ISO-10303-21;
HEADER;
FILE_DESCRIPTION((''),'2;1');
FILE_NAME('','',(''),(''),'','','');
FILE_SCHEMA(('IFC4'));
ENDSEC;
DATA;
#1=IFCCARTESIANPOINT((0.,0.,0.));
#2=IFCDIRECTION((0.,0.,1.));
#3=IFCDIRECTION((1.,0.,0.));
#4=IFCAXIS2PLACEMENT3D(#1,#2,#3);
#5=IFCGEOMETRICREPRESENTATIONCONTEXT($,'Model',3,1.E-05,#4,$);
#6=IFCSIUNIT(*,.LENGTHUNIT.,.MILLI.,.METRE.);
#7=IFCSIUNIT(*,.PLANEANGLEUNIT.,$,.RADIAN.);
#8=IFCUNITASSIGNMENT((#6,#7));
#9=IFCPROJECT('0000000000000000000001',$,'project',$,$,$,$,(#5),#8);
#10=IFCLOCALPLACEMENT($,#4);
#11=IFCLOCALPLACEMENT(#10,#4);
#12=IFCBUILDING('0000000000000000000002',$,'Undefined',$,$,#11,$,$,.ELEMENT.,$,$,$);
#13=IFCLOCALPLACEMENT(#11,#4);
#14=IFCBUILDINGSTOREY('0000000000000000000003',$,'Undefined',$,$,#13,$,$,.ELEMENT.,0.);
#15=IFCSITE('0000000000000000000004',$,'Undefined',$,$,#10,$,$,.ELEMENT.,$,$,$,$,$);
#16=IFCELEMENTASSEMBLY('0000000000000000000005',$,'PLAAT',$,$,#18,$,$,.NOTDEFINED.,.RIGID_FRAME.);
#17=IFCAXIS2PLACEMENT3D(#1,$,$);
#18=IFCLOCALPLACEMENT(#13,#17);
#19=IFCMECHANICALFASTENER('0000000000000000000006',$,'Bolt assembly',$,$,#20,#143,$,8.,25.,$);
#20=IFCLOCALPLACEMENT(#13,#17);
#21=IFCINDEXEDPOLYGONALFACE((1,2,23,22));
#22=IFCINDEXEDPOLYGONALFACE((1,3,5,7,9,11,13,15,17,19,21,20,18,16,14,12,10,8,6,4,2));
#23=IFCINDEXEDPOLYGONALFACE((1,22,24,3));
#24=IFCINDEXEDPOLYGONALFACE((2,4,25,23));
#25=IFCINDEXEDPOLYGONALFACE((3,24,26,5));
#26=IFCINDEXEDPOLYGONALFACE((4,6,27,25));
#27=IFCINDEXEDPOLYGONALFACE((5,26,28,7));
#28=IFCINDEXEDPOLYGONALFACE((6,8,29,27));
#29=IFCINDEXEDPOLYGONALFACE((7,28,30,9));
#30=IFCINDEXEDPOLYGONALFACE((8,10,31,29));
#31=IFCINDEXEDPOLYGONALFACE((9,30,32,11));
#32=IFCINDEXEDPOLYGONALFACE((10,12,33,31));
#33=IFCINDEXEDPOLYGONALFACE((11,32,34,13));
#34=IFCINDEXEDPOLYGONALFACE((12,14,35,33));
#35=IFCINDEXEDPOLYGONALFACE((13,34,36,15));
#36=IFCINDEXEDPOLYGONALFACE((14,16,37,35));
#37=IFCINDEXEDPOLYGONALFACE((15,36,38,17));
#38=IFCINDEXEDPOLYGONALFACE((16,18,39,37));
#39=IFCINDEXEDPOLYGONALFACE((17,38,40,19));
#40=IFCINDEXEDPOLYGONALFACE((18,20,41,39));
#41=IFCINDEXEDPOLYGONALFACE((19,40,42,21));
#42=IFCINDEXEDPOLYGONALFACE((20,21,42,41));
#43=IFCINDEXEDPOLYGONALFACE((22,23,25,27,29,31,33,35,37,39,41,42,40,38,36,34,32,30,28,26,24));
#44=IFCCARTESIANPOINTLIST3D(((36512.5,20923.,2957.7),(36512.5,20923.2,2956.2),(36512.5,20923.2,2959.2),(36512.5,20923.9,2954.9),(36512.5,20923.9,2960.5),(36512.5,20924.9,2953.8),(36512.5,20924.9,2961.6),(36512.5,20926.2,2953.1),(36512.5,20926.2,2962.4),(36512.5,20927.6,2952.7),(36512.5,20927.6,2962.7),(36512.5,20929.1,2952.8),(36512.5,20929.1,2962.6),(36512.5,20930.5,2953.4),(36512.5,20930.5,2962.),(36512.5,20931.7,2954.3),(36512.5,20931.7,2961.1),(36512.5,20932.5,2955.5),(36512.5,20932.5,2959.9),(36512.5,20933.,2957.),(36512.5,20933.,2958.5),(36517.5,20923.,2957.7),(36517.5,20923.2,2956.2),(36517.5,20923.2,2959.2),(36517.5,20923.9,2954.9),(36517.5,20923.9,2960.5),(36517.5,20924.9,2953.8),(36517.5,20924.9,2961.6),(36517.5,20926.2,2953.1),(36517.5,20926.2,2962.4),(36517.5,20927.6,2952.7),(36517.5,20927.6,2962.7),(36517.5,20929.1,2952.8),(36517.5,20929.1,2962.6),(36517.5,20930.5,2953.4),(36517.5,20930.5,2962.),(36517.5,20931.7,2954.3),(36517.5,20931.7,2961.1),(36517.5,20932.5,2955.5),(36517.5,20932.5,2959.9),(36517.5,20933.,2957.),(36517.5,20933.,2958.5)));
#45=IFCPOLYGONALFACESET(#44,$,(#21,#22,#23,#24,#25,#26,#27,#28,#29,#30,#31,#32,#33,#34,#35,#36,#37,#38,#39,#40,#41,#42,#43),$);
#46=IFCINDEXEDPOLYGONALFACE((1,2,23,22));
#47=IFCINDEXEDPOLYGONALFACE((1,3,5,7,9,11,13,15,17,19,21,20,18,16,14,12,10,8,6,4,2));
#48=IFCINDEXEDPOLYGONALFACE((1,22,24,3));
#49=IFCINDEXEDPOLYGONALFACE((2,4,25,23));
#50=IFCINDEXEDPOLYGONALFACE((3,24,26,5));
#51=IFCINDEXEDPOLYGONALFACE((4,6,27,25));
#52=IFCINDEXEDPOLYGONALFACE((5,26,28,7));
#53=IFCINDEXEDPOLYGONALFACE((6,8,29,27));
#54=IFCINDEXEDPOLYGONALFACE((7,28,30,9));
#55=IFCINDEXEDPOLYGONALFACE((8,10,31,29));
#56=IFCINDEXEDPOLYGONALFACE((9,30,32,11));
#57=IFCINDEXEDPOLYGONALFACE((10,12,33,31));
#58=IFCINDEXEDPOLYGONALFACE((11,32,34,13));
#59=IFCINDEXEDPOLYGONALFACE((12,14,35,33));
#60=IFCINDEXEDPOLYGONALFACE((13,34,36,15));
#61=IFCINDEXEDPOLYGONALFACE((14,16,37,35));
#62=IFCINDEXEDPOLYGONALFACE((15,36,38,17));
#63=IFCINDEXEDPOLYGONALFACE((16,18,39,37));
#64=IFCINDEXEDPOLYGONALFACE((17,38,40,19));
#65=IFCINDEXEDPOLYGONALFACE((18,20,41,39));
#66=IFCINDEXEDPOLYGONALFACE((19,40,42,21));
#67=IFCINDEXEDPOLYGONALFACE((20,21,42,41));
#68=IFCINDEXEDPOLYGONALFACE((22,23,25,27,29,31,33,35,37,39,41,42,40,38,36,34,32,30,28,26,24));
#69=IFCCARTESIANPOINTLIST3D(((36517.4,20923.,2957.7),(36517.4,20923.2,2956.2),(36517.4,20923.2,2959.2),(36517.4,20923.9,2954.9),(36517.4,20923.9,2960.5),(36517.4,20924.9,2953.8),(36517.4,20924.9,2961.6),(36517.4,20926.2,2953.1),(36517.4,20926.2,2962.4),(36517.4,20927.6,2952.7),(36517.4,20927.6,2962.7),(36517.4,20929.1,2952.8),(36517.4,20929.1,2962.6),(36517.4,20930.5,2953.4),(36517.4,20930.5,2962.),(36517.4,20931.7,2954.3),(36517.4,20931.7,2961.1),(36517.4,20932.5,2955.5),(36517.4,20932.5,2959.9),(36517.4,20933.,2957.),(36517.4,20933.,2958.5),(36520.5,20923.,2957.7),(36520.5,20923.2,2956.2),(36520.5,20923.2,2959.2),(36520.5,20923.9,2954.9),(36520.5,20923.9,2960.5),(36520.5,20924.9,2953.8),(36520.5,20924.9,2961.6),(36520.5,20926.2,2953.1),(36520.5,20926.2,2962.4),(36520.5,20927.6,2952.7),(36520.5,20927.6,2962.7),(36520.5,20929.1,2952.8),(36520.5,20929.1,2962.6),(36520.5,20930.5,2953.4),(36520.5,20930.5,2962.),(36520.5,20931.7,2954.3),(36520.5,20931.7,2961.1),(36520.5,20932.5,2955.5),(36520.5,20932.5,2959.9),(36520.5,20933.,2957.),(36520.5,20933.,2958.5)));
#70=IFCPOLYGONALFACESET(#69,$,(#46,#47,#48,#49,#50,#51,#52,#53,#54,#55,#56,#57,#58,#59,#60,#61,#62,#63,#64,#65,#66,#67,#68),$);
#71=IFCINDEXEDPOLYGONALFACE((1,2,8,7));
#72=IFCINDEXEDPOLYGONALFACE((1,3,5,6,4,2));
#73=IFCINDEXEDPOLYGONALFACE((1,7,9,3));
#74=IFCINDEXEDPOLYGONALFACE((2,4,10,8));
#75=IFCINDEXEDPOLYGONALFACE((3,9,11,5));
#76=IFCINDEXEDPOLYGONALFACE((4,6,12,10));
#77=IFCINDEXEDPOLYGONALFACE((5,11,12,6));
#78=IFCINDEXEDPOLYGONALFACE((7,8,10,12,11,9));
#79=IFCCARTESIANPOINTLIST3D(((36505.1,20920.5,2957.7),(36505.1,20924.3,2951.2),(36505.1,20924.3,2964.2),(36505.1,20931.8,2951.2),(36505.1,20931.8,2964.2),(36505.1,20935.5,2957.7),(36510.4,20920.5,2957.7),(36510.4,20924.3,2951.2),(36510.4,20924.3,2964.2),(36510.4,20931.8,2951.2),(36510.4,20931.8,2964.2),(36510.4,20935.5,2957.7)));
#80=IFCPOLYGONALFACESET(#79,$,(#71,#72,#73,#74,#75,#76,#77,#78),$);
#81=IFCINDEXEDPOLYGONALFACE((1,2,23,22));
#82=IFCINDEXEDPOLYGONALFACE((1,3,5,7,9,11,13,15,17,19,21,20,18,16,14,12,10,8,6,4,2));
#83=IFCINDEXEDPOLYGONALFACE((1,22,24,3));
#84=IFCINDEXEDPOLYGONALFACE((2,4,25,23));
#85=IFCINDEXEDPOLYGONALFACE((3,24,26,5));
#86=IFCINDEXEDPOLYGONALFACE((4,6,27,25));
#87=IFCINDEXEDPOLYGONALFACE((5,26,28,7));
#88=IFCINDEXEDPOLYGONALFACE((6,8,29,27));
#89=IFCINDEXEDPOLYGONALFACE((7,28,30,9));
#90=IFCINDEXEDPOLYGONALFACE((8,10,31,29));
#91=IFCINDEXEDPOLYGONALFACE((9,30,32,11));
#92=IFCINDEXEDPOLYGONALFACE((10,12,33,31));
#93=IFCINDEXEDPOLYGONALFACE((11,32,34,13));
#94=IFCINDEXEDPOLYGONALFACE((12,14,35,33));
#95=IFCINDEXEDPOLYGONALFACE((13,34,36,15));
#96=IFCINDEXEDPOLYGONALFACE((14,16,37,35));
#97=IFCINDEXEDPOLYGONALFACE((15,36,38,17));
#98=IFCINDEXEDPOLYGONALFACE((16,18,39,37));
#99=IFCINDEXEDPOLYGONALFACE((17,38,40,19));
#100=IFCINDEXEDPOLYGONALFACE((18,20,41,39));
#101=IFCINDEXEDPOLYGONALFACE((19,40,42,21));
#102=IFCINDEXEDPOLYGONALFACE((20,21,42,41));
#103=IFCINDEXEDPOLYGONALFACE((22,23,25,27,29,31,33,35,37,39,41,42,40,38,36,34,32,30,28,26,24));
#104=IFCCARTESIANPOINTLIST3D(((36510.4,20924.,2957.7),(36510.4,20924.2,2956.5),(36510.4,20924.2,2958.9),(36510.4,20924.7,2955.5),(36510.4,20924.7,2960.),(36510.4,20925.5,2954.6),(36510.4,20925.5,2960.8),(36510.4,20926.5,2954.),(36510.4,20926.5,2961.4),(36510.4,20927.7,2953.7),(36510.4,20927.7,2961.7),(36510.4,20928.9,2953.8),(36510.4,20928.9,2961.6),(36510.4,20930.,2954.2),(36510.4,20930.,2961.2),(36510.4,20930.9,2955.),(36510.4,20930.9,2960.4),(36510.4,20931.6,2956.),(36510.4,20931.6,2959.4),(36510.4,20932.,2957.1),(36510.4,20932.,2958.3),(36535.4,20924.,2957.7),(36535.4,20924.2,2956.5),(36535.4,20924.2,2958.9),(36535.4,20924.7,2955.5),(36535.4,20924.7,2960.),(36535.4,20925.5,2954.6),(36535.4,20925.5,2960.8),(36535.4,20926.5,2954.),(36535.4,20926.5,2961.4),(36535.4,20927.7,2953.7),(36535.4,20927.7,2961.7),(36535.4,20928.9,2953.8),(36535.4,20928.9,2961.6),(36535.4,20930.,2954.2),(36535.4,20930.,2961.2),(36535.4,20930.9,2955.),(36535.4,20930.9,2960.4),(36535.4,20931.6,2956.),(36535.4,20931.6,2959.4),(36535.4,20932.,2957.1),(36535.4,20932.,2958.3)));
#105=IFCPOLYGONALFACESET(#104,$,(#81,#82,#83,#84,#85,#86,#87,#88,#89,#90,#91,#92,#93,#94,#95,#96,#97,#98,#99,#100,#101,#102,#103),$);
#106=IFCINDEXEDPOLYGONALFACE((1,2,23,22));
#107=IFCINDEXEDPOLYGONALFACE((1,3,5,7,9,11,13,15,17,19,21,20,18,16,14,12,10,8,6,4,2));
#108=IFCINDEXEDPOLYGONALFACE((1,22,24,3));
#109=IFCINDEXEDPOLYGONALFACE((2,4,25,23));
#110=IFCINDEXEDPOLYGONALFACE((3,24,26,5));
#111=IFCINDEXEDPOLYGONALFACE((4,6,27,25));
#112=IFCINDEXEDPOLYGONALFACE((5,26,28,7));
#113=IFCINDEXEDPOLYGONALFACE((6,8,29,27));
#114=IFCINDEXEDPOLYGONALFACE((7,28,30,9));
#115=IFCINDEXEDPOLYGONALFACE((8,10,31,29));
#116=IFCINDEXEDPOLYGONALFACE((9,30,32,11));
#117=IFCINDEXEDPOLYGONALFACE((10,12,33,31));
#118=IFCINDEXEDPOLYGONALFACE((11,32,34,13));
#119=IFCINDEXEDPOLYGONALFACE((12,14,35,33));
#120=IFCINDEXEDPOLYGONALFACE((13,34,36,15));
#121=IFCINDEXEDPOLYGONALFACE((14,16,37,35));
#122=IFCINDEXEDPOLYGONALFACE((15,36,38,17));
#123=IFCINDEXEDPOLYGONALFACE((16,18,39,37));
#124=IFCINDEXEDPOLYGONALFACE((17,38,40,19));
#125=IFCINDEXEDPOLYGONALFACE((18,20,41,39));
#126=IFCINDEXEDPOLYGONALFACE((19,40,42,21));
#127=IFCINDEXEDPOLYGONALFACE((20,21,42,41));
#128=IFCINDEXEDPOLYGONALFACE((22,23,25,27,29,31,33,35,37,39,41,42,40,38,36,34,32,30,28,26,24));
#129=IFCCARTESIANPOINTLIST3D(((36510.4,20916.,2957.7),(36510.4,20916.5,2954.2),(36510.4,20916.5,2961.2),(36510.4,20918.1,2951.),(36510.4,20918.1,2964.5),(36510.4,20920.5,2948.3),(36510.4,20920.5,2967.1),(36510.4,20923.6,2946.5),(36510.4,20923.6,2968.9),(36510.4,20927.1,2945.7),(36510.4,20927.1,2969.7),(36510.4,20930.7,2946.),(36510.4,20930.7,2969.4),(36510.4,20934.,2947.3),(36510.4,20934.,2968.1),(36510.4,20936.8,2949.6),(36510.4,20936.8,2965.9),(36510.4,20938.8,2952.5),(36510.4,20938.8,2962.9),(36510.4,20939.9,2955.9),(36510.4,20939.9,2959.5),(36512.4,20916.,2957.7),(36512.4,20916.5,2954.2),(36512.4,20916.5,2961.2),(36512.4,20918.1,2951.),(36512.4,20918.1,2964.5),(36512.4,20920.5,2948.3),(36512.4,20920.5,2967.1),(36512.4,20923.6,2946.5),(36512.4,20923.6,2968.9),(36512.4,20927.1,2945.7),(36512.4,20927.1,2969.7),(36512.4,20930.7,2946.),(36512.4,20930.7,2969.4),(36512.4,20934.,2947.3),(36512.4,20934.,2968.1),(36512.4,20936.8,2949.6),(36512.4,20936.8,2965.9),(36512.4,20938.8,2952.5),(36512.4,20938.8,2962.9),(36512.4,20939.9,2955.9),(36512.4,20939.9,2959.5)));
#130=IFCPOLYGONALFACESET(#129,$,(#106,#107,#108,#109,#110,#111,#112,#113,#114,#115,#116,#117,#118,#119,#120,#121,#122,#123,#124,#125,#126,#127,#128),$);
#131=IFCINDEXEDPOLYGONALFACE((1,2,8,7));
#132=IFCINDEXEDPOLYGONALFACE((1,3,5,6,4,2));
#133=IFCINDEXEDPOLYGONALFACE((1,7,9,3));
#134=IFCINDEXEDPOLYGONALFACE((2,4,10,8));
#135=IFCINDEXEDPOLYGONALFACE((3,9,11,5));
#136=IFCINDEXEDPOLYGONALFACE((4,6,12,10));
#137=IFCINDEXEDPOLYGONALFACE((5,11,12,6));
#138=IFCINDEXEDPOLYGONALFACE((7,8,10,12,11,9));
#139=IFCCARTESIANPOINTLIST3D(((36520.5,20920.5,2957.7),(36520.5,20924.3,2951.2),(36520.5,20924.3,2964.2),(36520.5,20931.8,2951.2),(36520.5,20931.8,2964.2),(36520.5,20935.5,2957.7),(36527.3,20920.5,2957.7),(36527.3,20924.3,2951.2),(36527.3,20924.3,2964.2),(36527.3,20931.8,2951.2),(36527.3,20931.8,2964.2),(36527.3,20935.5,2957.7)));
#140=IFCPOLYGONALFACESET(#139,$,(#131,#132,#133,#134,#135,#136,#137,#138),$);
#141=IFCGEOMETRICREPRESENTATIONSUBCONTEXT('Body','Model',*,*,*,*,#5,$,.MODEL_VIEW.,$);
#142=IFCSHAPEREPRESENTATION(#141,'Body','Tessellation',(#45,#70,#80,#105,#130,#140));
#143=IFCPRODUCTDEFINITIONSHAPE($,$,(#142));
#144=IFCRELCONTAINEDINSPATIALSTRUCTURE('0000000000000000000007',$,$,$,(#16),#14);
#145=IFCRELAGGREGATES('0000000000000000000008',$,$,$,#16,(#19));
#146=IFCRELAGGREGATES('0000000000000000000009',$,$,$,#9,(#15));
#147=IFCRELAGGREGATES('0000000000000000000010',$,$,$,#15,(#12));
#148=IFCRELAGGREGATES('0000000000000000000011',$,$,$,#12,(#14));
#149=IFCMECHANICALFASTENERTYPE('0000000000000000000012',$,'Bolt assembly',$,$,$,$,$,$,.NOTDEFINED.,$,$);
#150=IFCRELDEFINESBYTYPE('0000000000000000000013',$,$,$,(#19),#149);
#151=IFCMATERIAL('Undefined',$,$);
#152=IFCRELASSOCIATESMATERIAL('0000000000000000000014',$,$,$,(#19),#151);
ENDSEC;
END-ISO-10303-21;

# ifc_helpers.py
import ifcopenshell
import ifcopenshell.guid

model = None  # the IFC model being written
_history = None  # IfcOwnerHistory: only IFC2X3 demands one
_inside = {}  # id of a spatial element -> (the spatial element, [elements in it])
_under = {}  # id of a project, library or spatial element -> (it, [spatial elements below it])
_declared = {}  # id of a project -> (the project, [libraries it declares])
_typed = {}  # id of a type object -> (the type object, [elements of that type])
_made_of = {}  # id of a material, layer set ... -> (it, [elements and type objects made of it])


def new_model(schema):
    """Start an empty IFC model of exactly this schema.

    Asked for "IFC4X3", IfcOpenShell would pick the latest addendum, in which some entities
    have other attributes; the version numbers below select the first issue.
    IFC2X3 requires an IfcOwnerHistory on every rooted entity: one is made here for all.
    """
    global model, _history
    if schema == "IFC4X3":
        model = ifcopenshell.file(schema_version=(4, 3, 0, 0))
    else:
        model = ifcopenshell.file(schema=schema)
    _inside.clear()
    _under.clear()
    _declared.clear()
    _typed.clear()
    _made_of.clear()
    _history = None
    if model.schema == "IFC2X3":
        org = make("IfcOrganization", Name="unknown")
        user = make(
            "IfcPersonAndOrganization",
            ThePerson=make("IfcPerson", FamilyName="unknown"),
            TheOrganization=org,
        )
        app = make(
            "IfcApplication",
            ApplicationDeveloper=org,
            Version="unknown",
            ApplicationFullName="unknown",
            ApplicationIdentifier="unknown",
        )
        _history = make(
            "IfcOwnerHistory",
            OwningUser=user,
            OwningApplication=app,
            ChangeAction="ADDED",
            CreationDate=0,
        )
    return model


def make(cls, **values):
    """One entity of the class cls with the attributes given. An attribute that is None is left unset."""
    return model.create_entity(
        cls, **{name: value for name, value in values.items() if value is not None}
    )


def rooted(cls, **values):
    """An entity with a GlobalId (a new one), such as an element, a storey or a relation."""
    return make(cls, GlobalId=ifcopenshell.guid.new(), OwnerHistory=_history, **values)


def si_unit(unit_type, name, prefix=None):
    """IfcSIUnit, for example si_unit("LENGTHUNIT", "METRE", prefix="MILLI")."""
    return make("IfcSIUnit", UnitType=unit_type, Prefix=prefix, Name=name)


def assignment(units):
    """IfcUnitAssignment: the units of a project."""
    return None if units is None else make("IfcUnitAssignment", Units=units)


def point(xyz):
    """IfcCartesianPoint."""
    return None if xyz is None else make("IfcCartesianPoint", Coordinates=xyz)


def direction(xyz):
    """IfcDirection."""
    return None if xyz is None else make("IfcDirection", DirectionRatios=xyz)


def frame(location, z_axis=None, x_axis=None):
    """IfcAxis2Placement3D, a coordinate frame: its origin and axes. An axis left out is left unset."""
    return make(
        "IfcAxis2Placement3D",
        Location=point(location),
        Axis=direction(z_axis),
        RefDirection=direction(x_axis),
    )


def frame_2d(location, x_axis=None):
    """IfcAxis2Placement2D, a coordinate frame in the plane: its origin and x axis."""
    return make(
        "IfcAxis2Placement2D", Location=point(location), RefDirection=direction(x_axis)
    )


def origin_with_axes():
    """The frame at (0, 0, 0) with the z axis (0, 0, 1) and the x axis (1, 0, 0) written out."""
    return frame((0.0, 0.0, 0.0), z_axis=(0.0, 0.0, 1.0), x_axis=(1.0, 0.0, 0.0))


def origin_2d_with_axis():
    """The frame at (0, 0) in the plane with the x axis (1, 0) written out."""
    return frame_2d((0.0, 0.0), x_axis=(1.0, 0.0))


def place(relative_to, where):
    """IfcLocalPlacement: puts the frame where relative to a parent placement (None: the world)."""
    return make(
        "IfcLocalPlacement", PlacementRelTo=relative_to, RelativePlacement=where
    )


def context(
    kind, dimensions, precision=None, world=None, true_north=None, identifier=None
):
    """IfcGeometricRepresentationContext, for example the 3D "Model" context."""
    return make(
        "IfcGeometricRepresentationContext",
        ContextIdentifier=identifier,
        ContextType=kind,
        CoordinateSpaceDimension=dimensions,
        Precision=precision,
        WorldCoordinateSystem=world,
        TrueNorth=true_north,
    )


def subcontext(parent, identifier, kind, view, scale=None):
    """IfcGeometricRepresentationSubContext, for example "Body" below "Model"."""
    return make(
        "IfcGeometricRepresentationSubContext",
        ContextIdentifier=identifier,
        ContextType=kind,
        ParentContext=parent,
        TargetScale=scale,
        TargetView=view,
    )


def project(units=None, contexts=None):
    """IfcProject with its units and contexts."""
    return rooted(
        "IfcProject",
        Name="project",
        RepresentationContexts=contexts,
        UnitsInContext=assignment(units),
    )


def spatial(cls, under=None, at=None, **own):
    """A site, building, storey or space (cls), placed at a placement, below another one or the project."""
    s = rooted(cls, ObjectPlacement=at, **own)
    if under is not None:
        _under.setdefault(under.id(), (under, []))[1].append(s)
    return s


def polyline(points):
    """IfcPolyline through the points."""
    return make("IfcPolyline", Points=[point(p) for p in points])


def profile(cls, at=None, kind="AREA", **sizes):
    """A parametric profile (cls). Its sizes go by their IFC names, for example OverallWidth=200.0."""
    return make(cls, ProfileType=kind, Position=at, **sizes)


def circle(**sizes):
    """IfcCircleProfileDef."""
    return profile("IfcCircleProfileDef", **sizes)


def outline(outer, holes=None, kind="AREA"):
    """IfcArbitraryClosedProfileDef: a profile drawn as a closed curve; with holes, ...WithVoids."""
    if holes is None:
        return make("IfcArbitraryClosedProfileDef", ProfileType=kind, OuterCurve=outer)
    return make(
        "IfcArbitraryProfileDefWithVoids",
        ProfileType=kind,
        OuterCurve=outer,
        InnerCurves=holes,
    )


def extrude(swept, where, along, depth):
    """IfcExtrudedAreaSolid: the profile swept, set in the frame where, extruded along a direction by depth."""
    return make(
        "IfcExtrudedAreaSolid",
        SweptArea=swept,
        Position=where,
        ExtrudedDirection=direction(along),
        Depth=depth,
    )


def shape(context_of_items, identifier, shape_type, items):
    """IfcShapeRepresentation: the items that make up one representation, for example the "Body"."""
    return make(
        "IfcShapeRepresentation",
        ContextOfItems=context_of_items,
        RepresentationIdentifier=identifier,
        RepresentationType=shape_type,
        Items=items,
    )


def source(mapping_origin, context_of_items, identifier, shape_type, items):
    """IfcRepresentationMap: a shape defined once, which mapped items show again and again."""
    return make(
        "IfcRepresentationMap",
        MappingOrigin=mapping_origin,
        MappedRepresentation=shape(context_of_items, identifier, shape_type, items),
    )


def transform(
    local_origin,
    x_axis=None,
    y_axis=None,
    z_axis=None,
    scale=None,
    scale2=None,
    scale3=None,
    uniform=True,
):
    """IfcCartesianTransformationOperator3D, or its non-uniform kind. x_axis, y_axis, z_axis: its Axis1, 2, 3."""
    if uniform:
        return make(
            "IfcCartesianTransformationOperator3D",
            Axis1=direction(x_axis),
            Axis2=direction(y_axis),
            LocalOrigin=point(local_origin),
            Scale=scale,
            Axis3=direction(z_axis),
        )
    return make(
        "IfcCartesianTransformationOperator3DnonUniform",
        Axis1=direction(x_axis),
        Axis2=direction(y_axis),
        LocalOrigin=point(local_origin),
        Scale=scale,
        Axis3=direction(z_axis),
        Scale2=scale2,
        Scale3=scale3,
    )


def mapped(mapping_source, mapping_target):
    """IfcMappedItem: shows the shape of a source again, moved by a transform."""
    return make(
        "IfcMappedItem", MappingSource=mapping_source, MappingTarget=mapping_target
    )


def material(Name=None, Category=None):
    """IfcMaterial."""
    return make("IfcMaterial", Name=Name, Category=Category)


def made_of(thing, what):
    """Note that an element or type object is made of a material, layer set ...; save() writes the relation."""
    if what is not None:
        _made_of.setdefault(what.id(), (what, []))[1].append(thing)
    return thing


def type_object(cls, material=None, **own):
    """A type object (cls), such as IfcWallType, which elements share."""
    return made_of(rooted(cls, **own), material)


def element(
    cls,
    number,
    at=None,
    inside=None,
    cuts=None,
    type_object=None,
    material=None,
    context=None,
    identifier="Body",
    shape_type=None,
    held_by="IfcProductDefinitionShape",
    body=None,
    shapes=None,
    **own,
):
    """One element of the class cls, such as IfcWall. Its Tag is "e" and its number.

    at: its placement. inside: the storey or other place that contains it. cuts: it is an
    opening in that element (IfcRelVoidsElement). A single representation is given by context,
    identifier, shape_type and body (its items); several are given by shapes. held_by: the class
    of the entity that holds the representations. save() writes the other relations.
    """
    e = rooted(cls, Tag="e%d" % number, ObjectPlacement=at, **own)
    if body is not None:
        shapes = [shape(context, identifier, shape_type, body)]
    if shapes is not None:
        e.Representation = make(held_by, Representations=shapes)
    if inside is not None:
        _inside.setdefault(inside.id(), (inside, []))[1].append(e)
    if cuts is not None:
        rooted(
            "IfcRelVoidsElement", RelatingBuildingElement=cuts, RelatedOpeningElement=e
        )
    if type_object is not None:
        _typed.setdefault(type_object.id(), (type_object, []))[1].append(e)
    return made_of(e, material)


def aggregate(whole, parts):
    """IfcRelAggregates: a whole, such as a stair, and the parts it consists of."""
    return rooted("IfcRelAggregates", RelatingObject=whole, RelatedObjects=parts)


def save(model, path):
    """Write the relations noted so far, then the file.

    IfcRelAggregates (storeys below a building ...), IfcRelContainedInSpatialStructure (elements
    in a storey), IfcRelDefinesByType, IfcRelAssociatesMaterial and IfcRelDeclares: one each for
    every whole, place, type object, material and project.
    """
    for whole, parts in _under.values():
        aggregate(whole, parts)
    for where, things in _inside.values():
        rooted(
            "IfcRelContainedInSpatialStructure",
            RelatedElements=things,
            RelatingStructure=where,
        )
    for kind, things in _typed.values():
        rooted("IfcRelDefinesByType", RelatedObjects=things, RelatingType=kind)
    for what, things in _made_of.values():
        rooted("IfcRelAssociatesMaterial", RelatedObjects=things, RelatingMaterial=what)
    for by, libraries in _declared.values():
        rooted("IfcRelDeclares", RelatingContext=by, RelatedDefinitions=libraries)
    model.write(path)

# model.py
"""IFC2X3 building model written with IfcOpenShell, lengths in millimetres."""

from ifc_helpers import new_model, si_unit, frame, origin_with_axes, origin_2d_with_axis, place, context, subcontext, project, spatial, polyline, circle, outline, extrude, source, transform, mapped, material, type_object, element, aggregate, save


model = new_model("IFC2X3")

# Units and contexts
model_context = context("Model", 3, precision=1e-05, world=origin_with_axes())
body_context = subcontext(model_context, "Body", "Model", "MODEL_VIEW")
ifc_project = project(units=[si_unit("LENGTHUNIT", "METRE", prefix="MILLI"), si_unit("PLANEANGLEUNIT", "RADIAN")], contexts=[model_context])

# Site, building, storey
site_placement = place(None, origin_with_axes())
site = spatial("IfcSite", under=ifc_project, at=site_placement, Name="Undefined", CompositionType="ELEMENT")
building_placement = place(site_placement, origin_with_axes())
building = spatial("IfcBuilding", under=site, at=building_placement, Name="Undefined", CompositionType="ELEMENT")
storey_placement = place(building_placement, origin_with_axes())
storey = spatial("IfcBuildingStorey", under=building, at=storey_placement, Name="Undefined", CompositionType="ELEMENT", Elevation=0.0)

# Shared definitions
ifc_material_1 = material(Name="Undefined")
mechanical_fastener_type = type_object("IfcMechanicalFastenerType", Name="Bolt assembly")
shared_shape_1 = source(origin_with_axes(), body_context, "Body", "SweptSolid", [
    extrude(circle(Radius=5.0, at=origin_2d_with_axis()), frame((0.0, 7.5, 0.0), z_axis=(0.0, 1.0, 0.0), x_axis=(1.0, 0.0, 0.0)), (0.0, 0.0, 1.0), 5.0),
    extrude(circle(Radius=5.0, at=origin_2d_with_axis()), frame((0.0, 12.4, 0.0), z_axis=(0.0, 1.0, 0.0), x_axis=(1.0, 0.0, 0.0)), (0.0, 0.0, 1.0), 3.1),
    extrude(outline(polyline([(7.5, 0.0), (3.8, 6.5), (-3.8, 6.5), (-7.5, 0.0), (-3.8, -6.5), (3.8, -6.5), (7.5, 0.0)])), frame((0.0, 0.1, 0.0), z_axis=(0.0, 1.0, 0.0), x_axis=(1.0, 0.0, 0.0)), (0.0, 0.0, 1.0), 5.3),
    extrude(circle(Radius=4.0, at=origin_2d_with_axis()), frame((0.0, 5.4, 0.0), z_axis=(0.0, 1.0, 0.0), x_axis=(1.0, 0.0, 0.0)), (0.0, 0.0, 1.0), 25.0),
    extrude(circle(Radius=12.0, at=origin_2d_with_axis()), frame((0.0, 5.4, 0.0), z_axis=(0.0, 1.0, 0.0), x_axis=(1.0, 0.0, 0.0)), (0.0, 0.0, 1.0), 2.0),
    extrude(outline(polyline([(7.5, 0.0), (3.8, 6.5), (-3.8, 6.5), (-7.5, 0.0), (-3.8, -6.5), (3.8, -6.5), (7.5, 0.0)])), frame((0.0, 15.5, 0.0), z_axis=(0.0, 1.0, 0.0), x_axis=(1.0, 0.0, 0.0)), (0.0, 0.0, 1.0), 6.8),
])

# Element assembly, mechanical fastener
assembly_1_placement = place(storey_placement, origin_with_axes())
assembly_1 = element("IfcElementAssembly", 1, at=assembly_1_placement, inside=storey, Name="PLAAT", AssemblyPlace="NOTDEFINED", PredefinedType="RIGID_FRAME")
mechanical_fastener_1_placement = place(assembly_1_placement, frame((36505.0, 20928.0, 2957.7), z_axis=(0.0, 0.000002, 1.0), x_axis=(0.0, -1.0, 0.000002)))
mechanical_fastener_1 = element("IfcMechanicalFastener", 2, at=mechanical_fastener_1_placement, type_object=mechanical_fastener_type, material=ifc_material_1, Name="Bolt assembly", NominalDiameter=8.0, NominalLength=25.0, context=body_context, shape_type="MappedRepresentation", body=[
    mapped(shared_shape_1, transform((0.0, 0.0, 0.0))),
])
aggregate(assembly_1, [mechanical_fastener_1])

save(model, "model.ifc")
